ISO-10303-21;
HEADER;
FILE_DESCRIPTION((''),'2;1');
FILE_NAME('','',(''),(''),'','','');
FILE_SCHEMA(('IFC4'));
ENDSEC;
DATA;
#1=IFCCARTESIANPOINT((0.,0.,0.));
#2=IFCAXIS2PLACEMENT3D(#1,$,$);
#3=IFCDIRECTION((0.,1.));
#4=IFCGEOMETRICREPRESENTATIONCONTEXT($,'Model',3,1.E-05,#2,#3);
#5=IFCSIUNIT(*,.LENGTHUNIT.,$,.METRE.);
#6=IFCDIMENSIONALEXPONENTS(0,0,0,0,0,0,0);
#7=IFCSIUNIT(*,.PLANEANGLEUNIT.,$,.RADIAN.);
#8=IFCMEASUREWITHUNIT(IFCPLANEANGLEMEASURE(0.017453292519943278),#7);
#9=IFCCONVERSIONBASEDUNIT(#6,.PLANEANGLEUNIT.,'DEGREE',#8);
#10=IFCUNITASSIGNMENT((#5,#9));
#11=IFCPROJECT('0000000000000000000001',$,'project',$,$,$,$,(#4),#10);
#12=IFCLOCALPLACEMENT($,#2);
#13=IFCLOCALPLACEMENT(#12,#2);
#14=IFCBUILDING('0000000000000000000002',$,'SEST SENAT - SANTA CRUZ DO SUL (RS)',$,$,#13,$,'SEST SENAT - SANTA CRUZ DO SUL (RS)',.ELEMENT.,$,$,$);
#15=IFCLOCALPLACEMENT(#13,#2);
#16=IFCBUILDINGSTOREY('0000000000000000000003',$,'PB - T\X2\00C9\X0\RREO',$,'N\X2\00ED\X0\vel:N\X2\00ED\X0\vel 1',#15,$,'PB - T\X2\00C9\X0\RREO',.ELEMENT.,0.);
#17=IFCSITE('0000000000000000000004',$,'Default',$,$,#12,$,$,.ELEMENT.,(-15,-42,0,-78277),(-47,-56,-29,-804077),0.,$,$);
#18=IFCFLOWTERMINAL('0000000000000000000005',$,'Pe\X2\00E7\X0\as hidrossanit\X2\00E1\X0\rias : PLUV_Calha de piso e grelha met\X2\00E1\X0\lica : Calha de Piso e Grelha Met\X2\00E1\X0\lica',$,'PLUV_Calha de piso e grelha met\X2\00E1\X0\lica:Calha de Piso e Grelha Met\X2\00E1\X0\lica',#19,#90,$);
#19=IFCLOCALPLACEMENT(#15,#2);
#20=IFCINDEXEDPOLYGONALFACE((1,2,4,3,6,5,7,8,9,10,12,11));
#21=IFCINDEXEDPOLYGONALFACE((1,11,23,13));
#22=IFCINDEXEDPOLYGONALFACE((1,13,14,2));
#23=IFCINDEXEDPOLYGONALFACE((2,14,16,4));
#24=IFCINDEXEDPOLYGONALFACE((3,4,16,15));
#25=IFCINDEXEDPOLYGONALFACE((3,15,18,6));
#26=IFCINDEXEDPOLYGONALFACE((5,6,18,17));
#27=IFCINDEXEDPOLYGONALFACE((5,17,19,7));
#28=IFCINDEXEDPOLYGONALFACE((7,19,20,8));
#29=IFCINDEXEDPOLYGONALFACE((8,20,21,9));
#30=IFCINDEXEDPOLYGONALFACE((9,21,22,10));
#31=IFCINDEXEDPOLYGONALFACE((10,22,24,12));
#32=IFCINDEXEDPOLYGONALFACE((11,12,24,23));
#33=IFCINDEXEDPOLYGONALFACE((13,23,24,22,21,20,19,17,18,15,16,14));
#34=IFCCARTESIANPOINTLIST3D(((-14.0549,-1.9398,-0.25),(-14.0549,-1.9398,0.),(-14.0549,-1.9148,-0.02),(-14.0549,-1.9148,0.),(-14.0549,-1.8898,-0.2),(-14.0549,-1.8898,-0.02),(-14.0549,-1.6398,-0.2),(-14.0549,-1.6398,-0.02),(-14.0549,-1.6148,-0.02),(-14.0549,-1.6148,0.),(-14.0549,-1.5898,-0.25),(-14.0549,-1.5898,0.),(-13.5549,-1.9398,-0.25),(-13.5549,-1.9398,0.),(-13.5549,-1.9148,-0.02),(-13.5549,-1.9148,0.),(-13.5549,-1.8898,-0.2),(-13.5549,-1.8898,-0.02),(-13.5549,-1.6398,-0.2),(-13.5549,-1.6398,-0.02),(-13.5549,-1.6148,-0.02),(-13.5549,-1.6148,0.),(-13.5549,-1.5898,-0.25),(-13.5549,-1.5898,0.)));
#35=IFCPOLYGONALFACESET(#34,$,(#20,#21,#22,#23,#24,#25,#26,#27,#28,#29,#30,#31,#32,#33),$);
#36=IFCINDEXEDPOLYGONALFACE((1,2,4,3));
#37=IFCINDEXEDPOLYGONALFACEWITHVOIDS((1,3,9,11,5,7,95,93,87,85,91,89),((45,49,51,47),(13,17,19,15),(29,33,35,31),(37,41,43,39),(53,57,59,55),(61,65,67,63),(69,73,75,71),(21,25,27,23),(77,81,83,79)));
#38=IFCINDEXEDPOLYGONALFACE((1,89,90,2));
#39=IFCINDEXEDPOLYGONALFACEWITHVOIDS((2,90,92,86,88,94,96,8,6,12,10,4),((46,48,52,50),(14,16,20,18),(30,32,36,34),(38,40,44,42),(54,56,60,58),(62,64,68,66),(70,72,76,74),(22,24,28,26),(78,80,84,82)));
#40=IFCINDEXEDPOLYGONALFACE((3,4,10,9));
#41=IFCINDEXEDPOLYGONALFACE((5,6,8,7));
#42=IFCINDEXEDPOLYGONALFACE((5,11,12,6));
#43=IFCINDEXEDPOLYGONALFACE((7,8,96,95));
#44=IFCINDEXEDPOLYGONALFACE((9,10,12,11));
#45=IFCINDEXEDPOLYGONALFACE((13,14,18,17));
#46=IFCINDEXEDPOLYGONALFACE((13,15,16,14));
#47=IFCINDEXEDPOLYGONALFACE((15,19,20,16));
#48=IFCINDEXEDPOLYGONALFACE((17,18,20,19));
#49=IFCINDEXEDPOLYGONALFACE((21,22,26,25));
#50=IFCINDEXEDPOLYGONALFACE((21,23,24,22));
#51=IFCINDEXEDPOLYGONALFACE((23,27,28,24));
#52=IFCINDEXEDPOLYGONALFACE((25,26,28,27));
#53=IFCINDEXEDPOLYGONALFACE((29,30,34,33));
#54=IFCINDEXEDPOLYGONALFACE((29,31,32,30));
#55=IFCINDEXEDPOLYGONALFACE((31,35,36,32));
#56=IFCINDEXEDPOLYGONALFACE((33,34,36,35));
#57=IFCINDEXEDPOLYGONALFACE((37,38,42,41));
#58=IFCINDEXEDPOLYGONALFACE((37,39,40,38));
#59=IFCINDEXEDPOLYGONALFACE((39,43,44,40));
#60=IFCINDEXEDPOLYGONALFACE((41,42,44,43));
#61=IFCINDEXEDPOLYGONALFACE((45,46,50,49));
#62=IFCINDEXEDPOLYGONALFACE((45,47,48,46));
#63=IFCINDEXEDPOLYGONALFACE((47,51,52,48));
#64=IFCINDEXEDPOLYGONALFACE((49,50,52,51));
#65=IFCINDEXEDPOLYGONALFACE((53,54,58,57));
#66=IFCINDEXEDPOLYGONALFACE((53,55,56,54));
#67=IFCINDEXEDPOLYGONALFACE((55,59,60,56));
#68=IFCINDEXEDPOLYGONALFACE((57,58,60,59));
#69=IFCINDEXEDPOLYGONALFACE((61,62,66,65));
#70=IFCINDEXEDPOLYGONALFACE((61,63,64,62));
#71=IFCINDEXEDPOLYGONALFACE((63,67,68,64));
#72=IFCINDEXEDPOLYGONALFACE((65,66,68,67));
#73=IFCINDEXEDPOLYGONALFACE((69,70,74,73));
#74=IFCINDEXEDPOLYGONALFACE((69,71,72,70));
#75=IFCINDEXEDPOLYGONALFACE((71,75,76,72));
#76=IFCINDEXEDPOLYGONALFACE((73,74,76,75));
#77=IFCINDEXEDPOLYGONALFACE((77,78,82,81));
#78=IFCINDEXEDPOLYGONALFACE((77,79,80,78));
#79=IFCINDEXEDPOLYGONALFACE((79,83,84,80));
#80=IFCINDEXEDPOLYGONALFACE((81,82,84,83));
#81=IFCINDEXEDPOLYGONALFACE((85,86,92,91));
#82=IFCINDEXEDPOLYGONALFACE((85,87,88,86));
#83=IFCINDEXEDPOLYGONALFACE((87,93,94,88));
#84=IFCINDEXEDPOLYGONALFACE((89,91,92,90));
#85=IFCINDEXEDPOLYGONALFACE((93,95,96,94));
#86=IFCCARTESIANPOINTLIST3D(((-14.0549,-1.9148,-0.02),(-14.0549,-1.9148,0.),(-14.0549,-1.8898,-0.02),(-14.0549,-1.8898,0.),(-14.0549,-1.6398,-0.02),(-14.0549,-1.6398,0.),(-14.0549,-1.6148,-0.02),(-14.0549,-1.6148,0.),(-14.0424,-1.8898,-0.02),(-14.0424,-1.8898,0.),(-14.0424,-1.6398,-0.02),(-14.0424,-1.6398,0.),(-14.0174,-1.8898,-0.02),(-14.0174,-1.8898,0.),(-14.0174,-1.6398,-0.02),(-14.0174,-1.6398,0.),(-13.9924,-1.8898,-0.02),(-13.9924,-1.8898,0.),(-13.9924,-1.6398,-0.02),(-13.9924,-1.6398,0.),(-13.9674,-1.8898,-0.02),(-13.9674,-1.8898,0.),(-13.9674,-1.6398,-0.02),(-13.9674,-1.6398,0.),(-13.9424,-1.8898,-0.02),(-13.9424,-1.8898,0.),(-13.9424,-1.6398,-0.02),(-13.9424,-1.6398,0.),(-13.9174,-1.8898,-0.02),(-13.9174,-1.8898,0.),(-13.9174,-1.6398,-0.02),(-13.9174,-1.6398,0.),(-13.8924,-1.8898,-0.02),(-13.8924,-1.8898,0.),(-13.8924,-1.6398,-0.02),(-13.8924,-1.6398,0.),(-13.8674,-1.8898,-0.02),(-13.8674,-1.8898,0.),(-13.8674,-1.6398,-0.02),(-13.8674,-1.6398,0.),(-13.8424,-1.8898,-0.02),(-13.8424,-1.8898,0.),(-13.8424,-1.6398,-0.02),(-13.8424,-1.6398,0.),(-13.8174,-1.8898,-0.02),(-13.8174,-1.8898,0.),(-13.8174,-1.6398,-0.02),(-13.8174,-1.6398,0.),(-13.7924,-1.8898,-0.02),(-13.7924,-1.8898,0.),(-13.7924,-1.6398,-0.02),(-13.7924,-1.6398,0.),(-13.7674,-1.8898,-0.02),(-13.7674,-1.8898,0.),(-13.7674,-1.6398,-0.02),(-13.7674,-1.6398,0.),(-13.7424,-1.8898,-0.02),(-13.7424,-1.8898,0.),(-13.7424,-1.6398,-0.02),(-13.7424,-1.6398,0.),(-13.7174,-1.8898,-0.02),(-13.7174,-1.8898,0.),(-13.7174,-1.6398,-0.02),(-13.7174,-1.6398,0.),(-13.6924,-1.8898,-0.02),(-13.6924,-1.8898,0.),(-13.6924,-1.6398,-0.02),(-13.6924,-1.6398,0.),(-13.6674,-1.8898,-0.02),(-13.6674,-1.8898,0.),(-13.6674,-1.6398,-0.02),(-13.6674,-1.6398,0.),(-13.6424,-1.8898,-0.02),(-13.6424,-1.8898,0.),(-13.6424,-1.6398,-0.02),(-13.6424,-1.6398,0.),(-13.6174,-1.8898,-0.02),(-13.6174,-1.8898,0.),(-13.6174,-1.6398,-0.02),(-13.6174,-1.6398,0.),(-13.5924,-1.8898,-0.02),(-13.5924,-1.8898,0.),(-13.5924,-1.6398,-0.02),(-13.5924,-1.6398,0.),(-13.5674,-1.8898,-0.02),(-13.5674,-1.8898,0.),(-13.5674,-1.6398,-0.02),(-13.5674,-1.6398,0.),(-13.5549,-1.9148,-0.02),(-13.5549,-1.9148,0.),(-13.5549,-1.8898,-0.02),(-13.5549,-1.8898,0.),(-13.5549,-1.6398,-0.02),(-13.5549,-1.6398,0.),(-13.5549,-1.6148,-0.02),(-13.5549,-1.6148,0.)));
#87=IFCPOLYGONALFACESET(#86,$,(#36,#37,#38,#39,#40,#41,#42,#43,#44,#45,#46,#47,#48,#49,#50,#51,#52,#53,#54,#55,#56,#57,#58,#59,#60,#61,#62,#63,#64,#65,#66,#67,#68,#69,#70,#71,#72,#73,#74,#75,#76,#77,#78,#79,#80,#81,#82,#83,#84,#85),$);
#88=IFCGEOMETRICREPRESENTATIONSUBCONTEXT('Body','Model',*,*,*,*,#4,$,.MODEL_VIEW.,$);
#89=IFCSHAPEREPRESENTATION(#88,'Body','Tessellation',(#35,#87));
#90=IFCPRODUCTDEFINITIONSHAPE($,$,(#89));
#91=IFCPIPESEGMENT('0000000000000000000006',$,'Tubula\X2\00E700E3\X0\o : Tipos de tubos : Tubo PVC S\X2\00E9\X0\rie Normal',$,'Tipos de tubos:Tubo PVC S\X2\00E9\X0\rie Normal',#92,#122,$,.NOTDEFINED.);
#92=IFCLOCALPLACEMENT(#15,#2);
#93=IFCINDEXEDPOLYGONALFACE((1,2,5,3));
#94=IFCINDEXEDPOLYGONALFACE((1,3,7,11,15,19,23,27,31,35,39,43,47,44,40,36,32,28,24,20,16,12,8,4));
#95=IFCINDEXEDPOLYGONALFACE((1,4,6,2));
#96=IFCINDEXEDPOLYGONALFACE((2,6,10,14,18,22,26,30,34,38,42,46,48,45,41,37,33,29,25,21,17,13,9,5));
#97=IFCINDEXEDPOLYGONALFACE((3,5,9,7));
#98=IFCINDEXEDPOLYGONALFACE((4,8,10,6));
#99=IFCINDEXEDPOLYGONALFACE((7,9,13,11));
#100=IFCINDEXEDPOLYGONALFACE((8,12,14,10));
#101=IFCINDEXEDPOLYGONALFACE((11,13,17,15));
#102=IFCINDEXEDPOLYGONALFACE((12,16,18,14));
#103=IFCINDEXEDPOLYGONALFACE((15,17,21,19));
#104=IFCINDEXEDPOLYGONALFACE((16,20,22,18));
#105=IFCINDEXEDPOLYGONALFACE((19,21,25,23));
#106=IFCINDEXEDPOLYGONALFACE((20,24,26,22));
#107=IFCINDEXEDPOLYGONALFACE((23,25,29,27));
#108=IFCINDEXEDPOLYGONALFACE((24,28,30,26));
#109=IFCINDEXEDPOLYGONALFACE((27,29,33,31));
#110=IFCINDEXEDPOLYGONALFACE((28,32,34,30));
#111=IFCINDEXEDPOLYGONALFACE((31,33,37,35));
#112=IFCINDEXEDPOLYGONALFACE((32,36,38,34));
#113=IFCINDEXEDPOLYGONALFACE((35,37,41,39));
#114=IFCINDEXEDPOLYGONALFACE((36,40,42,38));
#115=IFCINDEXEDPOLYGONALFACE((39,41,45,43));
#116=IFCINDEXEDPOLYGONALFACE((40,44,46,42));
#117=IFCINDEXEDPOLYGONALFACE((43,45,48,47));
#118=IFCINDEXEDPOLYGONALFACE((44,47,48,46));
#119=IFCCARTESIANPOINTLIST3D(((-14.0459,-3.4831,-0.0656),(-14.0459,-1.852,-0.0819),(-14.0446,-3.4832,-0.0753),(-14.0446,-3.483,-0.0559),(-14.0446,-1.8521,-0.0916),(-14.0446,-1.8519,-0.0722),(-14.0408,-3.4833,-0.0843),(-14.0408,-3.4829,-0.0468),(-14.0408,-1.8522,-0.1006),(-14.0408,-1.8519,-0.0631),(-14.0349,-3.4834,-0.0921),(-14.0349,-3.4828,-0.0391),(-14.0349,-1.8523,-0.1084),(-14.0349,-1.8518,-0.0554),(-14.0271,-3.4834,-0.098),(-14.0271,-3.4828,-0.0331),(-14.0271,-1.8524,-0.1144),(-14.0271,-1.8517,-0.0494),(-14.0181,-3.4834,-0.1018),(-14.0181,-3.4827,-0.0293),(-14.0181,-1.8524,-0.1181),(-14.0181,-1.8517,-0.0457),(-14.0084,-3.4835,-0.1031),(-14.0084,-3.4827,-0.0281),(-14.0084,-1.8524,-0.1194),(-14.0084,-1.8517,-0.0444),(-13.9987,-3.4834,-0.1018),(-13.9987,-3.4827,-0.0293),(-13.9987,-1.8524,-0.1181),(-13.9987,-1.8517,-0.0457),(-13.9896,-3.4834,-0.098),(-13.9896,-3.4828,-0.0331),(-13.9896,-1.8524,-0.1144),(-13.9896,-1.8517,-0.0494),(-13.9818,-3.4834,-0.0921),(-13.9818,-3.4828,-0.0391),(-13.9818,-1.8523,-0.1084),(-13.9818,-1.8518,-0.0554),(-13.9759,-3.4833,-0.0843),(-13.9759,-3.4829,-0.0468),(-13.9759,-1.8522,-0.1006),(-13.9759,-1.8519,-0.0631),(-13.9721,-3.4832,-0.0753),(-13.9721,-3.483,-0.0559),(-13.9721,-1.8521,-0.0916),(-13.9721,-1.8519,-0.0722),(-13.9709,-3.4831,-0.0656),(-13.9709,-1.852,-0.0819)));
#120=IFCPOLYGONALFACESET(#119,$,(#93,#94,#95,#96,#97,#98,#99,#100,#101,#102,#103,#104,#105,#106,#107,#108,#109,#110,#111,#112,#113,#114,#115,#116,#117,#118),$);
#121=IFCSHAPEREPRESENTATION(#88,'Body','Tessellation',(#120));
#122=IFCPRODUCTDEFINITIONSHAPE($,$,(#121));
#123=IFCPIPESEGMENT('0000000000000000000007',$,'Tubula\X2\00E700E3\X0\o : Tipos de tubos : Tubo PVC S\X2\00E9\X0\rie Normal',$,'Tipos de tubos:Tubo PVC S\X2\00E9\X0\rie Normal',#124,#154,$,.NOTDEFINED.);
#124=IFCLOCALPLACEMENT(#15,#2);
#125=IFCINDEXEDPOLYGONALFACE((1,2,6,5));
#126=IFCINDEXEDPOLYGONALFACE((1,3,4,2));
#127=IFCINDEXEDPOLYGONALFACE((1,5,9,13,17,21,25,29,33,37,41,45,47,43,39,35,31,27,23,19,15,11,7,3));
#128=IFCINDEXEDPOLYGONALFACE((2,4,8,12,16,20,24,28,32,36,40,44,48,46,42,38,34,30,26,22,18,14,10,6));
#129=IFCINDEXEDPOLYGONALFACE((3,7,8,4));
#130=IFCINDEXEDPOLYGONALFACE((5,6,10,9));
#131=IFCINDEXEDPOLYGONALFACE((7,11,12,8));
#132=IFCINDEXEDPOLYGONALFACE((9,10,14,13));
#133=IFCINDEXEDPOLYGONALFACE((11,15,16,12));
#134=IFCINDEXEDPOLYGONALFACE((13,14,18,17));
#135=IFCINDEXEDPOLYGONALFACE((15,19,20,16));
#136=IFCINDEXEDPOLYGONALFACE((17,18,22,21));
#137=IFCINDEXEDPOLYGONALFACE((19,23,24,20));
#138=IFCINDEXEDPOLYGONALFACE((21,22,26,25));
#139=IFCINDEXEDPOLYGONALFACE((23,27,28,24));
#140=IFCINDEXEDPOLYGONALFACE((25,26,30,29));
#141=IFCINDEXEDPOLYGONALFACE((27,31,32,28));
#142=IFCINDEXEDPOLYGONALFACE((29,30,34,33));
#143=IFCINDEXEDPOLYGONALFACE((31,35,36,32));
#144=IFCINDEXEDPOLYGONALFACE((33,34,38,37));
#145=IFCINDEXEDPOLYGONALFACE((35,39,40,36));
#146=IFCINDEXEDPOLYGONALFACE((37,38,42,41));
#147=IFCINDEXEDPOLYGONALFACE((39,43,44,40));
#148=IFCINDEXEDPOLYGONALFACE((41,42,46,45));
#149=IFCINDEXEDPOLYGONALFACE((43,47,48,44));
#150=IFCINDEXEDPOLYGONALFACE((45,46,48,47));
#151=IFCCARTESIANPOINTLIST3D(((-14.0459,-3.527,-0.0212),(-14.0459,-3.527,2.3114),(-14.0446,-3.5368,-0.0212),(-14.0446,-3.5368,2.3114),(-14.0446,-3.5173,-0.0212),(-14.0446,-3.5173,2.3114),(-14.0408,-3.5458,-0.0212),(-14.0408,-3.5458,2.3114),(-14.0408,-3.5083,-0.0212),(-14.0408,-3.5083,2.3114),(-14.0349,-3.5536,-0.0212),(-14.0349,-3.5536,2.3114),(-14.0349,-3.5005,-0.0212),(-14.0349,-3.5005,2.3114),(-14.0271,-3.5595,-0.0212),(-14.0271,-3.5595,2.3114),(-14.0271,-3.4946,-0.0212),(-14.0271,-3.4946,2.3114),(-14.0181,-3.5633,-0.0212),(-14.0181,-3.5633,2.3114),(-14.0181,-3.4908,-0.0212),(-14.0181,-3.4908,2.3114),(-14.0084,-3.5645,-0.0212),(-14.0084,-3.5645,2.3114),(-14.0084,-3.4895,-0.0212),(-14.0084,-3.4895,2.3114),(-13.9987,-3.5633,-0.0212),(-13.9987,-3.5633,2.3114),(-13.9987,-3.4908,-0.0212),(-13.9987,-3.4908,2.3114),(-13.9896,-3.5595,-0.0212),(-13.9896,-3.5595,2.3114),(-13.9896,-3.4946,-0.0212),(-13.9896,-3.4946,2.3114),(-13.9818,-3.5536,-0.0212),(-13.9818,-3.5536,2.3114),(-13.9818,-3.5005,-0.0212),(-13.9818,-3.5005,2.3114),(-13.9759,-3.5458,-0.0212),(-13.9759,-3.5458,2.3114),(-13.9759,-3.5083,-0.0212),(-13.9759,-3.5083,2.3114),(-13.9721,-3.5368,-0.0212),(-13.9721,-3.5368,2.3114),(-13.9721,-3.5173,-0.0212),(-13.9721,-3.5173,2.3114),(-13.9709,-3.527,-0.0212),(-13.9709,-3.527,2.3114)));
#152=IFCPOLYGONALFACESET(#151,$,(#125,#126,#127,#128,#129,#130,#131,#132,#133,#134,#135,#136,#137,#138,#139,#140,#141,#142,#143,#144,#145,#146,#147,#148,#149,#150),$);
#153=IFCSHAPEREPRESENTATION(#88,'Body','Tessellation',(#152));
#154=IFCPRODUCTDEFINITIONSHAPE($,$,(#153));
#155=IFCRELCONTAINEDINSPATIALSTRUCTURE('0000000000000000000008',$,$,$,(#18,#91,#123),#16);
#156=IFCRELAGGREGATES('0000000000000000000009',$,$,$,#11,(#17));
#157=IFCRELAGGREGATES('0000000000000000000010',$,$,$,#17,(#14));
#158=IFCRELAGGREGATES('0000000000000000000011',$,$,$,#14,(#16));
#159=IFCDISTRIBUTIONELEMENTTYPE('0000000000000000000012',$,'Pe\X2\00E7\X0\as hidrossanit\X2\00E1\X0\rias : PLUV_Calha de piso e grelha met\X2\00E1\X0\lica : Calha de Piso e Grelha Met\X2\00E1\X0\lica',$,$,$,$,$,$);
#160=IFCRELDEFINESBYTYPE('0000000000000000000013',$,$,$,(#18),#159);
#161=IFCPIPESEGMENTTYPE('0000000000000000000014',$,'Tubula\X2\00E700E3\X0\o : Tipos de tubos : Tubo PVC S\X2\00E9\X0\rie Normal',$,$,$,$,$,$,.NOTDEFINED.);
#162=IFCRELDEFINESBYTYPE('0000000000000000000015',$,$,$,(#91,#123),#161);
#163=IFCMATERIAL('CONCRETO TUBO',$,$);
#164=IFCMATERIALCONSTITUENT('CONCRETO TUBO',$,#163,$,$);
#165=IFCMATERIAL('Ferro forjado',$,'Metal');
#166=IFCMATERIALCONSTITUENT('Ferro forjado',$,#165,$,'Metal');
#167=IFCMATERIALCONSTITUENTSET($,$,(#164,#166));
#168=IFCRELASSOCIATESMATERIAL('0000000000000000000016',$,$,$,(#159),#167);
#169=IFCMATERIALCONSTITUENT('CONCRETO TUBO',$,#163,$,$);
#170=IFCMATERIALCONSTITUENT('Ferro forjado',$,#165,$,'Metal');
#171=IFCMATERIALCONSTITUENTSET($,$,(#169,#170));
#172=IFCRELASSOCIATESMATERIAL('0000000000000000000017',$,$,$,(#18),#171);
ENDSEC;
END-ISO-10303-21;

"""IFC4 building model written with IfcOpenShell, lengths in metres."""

from ifc_helpers import new_model, entity, si_unit, converted_unit, direction, frame, origin, place, context, subcontext, project, spatial, arc, indexed_curve, outline, extrude, source, transform, mapped, material, constituent, constituent_set, type_object, type_shapes, element, save


model = new_model("IFC4")

# Units and contexts
model_context = context("Model", 3, precision=1e-05, world=origin(), true_north=direction((0.0, 1.0)))
body_context = subcontext(model_context, "Body", "Model", "MODEL_VIEW")
ifc_project = project(units=[si_unit("LENGTHUNIT", "METRE"), converted_unit("PLANEANGLEUNIT", "DEGREE", entity("IfcPlaneAngleMeasure", 0.017453292519943278), si_unit("PLANEANGLEUNIT", "RADIAN"), dimensions=[0, 0, 0, 0, 0, 0, 0])], contexts=[model_context])

# Site, building, storey
site_placement = place(None, origin())
site = spatial("IfcSite", under=ifc_project, at=site_placement, Name="Default", CompositionType="ELEMENT", RefLatitude=(-15, -42, 0, -78277), RefLongitude=(-47, -56, -29, -804077), RefElevation=0.0)
building_placement = place(site_placement, origin())
building = spatial("IfcBuilding", under=site, at=building_placement, Name="SEST SENAT - SANTA CRUZ DO SUL (RS)", LongName="SEST SENAT - SANTA CRUZ DO SUL (RS)", CompositionType="ELEMENT")
storey_placement = place(building_placement, origin())
storey = spatial("IfcBuildingStorey", under=building, at=storey_placement, Name="PB - TÉRREO", ObjectType="Nível:Nível 1", LongName="PB - TÉRREO", CompositionType="ELEMENT", Elevation=0.0)

# Flow terminal
ifc_material_1 = material(Name="CONCRETO TUBO")
ifc_constituent_1 = constituent(ifc_material_1, Name="CONCRETO TUBO")
ifc_material_2 = material(Name="Ferro forjado", Category="Metal")
ifc_constituent_2 = constituent(ifc_material_2, Name="Ferro forjado", Category="Metal")
ifc_constituent_set_1 = constituent_set(constituents=[ifc_constituent_1, ifc_constituent_2])
ifc_constituent_3 = constituent(ifc_material_1, Name="CONCRETO TUBO")
ifc_constituent_4 = constituent(ifc_material_2, Name="Ferro forjado", Category="Metal")
ifc_constituent_set_2 = constituent_set(constituents=[ifc_constituent_3, ifc_constituent_4])
distribution_element_type = type_object("IfcDistributionElementType", Name="Peças hidrossanitárias : PLUV_Calha de piso e grelha metálica : Calha de Piso e Grelha Metálica", material=ifc_constituent_set_2)
shared_shape_1 = source(origin(), body_context, "Body", "SweptSolid", [
    extrude(outline(indexed_curve([(-0.175, -0.0817), (-0.15, -0.0817), (-0.15, -0.0617), (-0.125, -0.0617), (-0.125, 0.1183), (0.125, 0.1183), (0.125, -0.0617), (0.15, -0.0617), (0.15, -0.0817), (0.175, -0.0817), (0.175, 0.1683), (-0.175, 0.1683), (-0.175, -0.0817)], self_intersect=False)), frame((-0.25, 0.0, -0.0817), z_axis=(1.0, 0.0, 0.0), x_axis=(0.0, -1.0, 0.0)), (0.0, 0.0, 1.0), 0.5),
    extrude(outline(indexed_curve([(0.125, -0.25), (0.15, -0.25), (0.15, 0.25), (0.125, 0.25), (0.125, 0.2375), (-0.125, 0.2375), (-0.125, 0.25), (-0.15, 0.25), (-0.15, -0.25), (-0.125, -0.25), (-0.125, -0.2375), (0.125, -0.2375), (0.125, -0.25)], self_intersect=False), holes=[indexed_curve([(0.125, 0.2125), (0.125, 0.1875), (-0.125, 0.1875), (-0.125, 0.2125), (0.125, 0.2125)], self_intersect=False), indexed_curve([(0.125, 0.1625), (0.125, 0.1375), (-0.125, 0.1375), (-0.125, 0.1625), (0.125, 0.1625)], self_intersect=False), indexed_curve([(0.125, 0.1125), (0.125, 0.0875), (-0.125, 0.0875), (-0.125, 0.1125), (0.125, 0.1125)], self_intersect=False), indexed_curve([(0.125, 0.0625), (0.125, 0.0375), (-0.125, 0.0375), (-0.125, 0.0625), (0.125, 0.0625)], self_intersect=False), indexed_curve([(0.125, 0.0125), (0.125, -0.0125), (-0.125, -0.0125), (-0.125, 0.0125), (0.125, 0.0125)], self_intersect=False), indexed_curve([(0.125, -0.0375), (0.125, -0.0625), (-0.125, -0.0625), (-0.125, -0.0375), (0.125, -0.0375)], self_intersect=False), indexed_curve([(0.125, -0.0875), (0.125, -0.1125), (-0.125, -0.1125), (-0.125, -0.0875), (0.125, -0.0875)], self_intersect=False), indexed_curve([(0.125, -0.1375), (0.125, -0.1625), (-0.125, -0.1625), (-0.125, -0.1375), (0.125, -0.1375)], self_intersect=False), indexed_curve([(0.125, -0.1875), (0.125, -0.2125), (-0.125, -0.2125), (-0.125, -0.1875), (0.125, -0.1875)], self_intersect=False)]), frame((0.0, 0.0, -0.02), z_axis=(0.0, 0.0, 1.0), x_axis=(0.0, 1.0, 0.0)), (0.0, 0.0, 1.0), 0.02),
])
type_shapes(distribution_element_type, [shared_shape_1])
flow_terminal_placement = place(storey_placement, frame((-13.8049, -1.7648, 0.0)))
element("IfcFlowTerminal", 1, at=flow_terminal_placement, inside=storey, type_object=distribution_element_type, material=ifc_constituent_set_1, Name="Peças hidrossanitárias : PLUV_Calha de piso e grelha metálica : Calha de Piso e Grelha Metálica", ObjectType="PLUV_Calha de piso e grelha metálica:Calha de Piso e Grelha Metálica", context=body_context, shape_type="MappedRepresentation", body=[
    mapped(shared_shape_1, transform((0.0, 0.0, 0.0), scale=1.0)),
])

# Pipe segments
pipe_segment_type_1 = type_object("IfcPipeSegmentType", Name="Tubulação : Tipos de tubos : Tubo PVC Série Normal", PredefinedType="NOTDEFINED")
pipe_segment_1_placement = place(storey_placement, frame((-14.0475, -3.4851, -0.0265)))
element("IfcPipeSegment", 2, at=pipe_segment_1_placement, inside=storey, type_object=pipe_segment_type_1, Name="Tubulação : Tipos de tubos : Tubo PVC Série Normal", ObjectType="Tipos de tubos:Tubo PVC Série Normal", PredefinedType="NOTDEFINED", context=body_context, shape_type="SweptSolid", body=[
    extrude(outline(indexed_curve([(0.0375, 0.0), (0.0265, 0.0265), (0.0, 0.0375), (-0.0265, 0.0265), (-0.0375, 0.0), (-0.0265, -0.0265), (0.0, -0.0375), (0.0265, -0.0265)], segments=[arc(1, 2, 3), arc(3, 4, 5), arc(5, 6, 7), arc(7, 8, 1)], self_intersect=False)), frame((0.0391, 1.633, -0.0554), z_axis=(0.0, -0.99995, 0.01), x_axis=(1.0, 0.0, 0.0)), (0.0, 0.0, 1.0), 1.6311),
])
pipe_segment_2_placement = place(storey_placement, frame((-14.0475, -3.5661, -0.0212)))
element("IfcPipeSegment", 3, at=pipe_segment_2_placement, inside=storey, type_object=pipe_segment_type_1, Name="Tubulação : Tipos de tubos : Tubo PVC Série Normal", ObjectType="Tipos de tubos:Tubo PVC Série Normal", PredefinedType="NOTDEFINED", context=body_context, shape_type="SweptSolid", body=[
    extrude(outline(indexed_curve([(0.0375, 0.0), (0.0265, 0.0265), (0.0, 0.0375), (-0.0265, 0.0265), (-0.0375, 0.0), (-0.0265, -0.0265), (0.0, -0.0375), (0.0265, -0.0265)], segments=[arc(1, 2, 3), arc(3, 4, 5), arc(5, 6, 7), arc(7, 8, 1)], self_intersect=False)), frame((0.0391, 0.0391, 0.0)), (0.0, 0.0, 1.0), 2.3325),
])

save(model, "model.ifc")
